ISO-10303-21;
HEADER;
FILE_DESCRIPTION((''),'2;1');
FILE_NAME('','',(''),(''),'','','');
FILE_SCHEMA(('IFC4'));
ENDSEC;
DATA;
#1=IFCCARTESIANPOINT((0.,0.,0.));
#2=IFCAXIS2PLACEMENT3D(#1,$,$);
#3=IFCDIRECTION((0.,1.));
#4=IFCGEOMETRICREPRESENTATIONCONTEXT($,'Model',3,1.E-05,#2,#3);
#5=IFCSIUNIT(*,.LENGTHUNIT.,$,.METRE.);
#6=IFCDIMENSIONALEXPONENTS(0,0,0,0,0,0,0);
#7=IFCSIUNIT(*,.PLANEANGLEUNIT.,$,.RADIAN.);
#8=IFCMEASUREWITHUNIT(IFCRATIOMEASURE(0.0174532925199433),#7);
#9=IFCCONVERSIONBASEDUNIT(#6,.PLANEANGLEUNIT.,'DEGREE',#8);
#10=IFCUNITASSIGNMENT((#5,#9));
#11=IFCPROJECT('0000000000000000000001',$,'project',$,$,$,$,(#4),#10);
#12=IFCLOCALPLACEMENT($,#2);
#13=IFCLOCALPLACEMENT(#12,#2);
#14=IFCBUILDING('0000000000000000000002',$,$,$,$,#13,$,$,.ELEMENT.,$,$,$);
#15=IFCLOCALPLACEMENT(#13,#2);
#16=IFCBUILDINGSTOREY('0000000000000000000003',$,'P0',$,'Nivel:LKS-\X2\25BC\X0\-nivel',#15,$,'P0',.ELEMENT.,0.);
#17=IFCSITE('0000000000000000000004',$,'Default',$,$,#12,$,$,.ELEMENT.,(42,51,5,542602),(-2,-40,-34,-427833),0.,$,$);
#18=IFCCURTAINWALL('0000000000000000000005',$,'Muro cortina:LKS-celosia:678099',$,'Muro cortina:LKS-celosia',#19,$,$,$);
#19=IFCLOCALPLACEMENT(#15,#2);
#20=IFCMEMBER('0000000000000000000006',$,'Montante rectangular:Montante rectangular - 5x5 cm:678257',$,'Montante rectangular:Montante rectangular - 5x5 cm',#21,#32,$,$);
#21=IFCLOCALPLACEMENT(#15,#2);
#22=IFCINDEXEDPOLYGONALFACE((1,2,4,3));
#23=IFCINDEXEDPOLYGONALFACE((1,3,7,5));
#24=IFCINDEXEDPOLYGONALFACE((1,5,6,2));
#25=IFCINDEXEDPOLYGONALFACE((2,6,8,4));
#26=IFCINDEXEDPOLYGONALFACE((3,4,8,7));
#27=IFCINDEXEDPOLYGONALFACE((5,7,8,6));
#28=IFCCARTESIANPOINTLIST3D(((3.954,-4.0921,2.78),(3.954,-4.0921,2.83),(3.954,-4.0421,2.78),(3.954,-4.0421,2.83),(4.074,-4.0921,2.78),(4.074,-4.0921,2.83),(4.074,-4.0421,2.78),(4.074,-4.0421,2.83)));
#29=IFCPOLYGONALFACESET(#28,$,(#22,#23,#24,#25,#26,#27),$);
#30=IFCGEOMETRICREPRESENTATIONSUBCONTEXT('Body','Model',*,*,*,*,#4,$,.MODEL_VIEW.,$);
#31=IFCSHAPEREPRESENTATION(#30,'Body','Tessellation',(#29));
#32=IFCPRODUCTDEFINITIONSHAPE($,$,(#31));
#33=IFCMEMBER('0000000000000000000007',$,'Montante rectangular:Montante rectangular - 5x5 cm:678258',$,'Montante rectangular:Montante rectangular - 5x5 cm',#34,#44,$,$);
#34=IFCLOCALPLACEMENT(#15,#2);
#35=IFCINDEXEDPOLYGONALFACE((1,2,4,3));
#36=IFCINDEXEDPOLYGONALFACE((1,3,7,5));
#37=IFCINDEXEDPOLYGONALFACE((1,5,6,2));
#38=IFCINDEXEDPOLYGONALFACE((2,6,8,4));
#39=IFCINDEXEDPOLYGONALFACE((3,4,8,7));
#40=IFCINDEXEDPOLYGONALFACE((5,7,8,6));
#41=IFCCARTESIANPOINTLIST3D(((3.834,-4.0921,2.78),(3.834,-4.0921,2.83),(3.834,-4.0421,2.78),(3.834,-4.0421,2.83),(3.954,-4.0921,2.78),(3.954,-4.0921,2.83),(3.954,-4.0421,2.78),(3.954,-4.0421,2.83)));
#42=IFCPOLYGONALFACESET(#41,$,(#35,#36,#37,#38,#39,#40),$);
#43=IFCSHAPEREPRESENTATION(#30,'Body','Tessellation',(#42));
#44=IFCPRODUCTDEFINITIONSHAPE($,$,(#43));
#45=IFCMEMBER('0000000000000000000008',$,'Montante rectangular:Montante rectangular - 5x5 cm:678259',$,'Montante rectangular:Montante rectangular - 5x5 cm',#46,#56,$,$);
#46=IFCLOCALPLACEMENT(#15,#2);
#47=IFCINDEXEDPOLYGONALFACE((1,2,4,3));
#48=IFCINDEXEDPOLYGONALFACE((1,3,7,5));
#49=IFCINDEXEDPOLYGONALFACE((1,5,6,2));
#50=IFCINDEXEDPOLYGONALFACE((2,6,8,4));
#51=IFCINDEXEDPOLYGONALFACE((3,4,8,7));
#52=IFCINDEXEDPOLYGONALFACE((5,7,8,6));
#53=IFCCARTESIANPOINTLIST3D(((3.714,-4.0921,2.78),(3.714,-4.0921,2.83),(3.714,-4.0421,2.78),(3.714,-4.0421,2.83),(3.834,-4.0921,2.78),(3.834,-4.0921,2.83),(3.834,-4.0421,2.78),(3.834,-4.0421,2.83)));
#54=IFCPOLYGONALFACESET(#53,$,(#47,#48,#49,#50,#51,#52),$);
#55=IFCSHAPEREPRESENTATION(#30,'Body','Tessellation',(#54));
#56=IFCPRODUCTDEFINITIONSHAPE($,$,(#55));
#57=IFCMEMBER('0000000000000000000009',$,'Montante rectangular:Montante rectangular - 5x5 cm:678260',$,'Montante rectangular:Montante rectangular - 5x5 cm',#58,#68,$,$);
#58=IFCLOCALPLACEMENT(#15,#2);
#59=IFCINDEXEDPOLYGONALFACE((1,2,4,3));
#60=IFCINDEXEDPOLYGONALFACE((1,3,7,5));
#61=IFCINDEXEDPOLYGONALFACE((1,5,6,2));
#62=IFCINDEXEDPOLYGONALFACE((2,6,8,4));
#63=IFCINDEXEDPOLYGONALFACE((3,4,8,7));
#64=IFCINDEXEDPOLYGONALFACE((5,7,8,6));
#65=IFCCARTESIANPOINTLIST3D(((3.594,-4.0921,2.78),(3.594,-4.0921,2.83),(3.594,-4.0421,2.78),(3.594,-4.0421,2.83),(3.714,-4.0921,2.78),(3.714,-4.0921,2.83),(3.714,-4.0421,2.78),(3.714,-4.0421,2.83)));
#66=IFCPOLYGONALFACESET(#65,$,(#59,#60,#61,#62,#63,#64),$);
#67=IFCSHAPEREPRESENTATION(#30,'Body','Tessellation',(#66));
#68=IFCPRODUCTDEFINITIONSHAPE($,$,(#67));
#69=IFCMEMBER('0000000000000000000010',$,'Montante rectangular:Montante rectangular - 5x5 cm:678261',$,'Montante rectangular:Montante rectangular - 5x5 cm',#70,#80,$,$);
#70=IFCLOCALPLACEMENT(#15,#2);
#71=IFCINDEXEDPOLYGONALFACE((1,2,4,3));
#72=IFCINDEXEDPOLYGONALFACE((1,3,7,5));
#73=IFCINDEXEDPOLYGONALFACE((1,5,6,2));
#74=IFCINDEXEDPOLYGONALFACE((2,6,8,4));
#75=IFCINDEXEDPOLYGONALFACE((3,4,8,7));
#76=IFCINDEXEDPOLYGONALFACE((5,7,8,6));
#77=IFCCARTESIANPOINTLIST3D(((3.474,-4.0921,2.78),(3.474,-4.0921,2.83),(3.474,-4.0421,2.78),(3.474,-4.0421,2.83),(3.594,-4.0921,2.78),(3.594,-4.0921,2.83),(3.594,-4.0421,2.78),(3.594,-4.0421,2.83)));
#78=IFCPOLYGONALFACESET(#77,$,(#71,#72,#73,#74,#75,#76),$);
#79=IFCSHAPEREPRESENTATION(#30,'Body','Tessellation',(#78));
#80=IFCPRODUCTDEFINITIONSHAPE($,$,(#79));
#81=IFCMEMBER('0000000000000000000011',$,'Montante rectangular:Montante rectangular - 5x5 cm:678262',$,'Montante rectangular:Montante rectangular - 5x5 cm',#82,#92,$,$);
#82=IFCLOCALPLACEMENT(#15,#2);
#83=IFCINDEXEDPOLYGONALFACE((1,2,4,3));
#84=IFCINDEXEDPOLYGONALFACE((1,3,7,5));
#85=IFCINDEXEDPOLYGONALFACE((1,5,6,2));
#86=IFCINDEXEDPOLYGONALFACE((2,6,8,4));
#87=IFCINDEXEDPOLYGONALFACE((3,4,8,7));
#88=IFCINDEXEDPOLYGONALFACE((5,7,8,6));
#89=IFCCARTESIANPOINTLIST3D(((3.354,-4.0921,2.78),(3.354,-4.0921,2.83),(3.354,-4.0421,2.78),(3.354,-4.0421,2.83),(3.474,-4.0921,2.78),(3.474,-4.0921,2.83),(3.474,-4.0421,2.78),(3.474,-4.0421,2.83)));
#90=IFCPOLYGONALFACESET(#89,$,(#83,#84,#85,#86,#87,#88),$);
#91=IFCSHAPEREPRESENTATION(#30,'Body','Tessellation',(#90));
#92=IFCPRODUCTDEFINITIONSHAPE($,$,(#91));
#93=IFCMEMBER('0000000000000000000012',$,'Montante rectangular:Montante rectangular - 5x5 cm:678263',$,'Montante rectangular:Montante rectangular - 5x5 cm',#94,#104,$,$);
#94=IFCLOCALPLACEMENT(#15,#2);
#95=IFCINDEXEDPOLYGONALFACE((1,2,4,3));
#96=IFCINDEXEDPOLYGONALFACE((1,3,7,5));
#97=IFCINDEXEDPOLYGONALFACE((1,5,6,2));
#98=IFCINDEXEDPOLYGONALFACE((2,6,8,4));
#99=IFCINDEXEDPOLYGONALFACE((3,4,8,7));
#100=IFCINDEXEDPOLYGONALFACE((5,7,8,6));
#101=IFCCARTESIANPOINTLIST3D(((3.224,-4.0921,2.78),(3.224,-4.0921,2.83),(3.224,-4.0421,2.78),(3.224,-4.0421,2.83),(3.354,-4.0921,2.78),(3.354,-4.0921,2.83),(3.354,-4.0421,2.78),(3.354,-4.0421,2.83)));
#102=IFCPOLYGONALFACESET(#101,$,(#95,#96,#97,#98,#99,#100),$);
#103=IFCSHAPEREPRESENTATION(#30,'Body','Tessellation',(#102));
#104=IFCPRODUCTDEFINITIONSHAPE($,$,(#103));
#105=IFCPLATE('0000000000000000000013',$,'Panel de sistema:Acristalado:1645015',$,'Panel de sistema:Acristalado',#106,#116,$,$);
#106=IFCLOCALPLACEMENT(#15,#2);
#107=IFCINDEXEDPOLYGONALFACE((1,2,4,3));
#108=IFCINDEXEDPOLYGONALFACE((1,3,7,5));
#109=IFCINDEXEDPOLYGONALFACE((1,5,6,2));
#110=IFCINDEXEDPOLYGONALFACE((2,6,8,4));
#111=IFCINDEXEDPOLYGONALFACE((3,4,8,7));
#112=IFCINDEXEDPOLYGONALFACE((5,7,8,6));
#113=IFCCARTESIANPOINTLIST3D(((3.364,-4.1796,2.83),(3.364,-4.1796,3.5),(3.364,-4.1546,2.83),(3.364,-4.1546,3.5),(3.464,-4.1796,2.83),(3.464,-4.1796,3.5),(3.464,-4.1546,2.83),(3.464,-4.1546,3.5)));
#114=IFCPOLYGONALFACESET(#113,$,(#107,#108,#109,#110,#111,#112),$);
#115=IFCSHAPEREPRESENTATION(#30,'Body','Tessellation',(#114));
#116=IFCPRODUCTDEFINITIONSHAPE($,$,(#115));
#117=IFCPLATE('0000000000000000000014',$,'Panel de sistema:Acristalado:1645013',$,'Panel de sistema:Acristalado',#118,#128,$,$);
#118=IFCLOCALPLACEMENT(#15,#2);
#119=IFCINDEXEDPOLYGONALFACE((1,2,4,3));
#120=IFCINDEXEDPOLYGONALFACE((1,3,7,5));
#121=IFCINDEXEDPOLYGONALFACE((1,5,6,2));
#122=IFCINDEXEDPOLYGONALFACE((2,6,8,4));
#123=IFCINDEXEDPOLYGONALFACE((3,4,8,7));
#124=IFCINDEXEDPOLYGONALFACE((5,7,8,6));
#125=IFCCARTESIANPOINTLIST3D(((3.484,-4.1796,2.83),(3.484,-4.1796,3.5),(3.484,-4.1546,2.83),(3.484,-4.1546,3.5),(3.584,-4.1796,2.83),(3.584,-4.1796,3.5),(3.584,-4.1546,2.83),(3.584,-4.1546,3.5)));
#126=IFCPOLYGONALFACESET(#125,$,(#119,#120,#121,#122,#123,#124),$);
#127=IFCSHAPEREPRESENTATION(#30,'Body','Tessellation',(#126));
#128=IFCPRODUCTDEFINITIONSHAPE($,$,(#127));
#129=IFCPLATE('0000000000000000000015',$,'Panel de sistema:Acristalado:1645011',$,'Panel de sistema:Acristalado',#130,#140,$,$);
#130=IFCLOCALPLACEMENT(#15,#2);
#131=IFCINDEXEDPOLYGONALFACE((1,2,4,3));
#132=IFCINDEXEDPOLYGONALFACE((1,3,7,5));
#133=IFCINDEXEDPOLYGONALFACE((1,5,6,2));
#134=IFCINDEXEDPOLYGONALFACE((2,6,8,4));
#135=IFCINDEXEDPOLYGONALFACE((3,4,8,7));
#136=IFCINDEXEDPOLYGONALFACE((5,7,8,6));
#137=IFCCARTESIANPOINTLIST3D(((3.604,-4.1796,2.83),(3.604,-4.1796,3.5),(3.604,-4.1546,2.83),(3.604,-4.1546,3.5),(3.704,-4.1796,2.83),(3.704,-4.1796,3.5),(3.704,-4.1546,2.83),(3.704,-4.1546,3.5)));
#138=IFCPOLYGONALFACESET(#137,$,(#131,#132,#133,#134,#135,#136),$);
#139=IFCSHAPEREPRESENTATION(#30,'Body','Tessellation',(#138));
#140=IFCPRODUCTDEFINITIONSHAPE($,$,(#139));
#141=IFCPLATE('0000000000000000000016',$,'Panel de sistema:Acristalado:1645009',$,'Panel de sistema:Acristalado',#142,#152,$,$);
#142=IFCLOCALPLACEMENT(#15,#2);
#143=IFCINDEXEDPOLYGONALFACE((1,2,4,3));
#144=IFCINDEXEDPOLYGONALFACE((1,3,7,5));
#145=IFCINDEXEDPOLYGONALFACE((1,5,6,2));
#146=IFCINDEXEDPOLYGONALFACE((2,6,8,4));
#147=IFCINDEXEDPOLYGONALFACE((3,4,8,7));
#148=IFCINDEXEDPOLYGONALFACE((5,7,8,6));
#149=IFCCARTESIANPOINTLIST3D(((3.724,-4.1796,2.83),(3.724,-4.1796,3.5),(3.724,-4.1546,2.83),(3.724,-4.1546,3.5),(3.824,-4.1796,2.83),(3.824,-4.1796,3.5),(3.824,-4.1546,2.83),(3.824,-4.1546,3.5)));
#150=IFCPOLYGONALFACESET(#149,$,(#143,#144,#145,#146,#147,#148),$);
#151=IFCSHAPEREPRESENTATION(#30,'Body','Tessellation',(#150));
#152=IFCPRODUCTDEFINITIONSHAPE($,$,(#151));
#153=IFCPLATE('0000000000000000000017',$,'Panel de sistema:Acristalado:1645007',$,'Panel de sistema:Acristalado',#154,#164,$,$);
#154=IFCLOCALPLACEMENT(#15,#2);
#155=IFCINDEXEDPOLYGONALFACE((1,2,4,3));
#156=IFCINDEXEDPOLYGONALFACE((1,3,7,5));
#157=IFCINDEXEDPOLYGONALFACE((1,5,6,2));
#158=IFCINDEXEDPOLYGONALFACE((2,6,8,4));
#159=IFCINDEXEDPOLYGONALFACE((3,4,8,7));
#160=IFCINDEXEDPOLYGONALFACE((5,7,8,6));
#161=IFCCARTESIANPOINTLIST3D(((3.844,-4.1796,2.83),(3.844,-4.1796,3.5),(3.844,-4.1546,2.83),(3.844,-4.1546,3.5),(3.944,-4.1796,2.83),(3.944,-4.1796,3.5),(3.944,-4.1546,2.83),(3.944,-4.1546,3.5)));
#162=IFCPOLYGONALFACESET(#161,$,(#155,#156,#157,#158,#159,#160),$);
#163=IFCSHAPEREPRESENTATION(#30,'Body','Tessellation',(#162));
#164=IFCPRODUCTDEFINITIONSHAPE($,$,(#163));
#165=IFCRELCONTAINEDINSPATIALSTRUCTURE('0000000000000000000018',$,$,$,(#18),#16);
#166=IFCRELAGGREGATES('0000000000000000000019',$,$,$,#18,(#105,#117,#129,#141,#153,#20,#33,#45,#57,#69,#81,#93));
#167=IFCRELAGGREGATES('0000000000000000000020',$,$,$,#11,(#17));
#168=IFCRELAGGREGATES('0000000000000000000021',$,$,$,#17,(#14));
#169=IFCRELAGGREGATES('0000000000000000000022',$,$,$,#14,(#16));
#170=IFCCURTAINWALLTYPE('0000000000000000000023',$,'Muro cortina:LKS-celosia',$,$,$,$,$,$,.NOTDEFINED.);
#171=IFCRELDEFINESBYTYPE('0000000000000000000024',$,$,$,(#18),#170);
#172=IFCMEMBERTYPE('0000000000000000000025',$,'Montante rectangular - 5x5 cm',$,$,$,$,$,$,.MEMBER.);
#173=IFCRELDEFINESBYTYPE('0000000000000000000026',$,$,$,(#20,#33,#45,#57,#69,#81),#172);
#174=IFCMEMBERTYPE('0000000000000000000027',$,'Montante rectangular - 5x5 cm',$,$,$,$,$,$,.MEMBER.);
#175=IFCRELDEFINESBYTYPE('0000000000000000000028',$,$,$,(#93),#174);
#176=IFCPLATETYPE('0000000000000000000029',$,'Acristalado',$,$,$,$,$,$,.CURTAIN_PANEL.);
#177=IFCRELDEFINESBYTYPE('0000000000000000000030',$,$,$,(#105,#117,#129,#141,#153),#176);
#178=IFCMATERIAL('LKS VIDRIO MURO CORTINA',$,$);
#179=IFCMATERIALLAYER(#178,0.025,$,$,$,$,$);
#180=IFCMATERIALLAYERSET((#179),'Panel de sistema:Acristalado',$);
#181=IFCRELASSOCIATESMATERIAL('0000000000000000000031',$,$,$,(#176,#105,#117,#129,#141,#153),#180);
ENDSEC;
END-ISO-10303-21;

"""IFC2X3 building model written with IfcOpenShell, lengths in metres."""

from ifc_helpers import new_model, entity, si_unit, converted_unit, direction, frame, origin, origin_2d_with_axis, place, context, subcontext, project, spatial, rectangle, extrude, source, transform, mapped, material, layer, layer_set, layer_usage, type_object, type_shapes, element, aggregate, save


model = new_model("IFC2X3")

# Units and contexts
model_context = context("Model", 3, precision=1e-05, world=origin(), true_north=direction((0.0, 1.0)))
body_context = subcontext(model_context, "Body", "Model", "MODEL_VIEW")
ifc_project = project(units=[si_unit("LENGTHUNIT", "METRE"), converted_unit("PLANEANGLEUNIT", "DEGREE", entity("IfcRatioMeasure", 0.0174532925199433), si_unit("PLANEANGLEUNIT", "RADIAN"), dimensions=[0, 0, 0, 0, 0, 0, 0])], contexts=[model_context])

# Site, building, storey
site_placement = place(None, origin())
site = spatial("IfcSite", under=ifc_project, at=site_placement, Name="Default", CompositionType="ELEMENT", RefLatitude=(42, 51, 5, 542602), RefLongitude=(-2, -40, -34, -427833), RefElevation=0.0)
building_placement = place(site_placement, origin())
building = spatial("IfcBuilding", under=site, at=building_placement, CompositionType="ELEMENT")
storey_placement = place(building_placement, origin())
storey = spatial("IfcBuildingStorey", under=building, at=storey_placement, Name="P0", ObjectType="Nivel:LKS-▼-nivel", LongName="P0", CompositionType="ELEMENT", Elevation=0.0)

# Curtain wall, members, plates
curtain_wall_type = type_object("IfcCurtainWallType", Name="Muro cortina:LKS-celosia", PredefinedType="NOTDEFINED")
curtain_wall_placement = place(storey_placement, origin())
curtain_wall = element("IfcCurtainWall", 1, at=curtain_wall_placement, inside=storey, type_object=curtain_wall_type, Name="Muro cortina:LKS-celosia:678099", ObjectType="Muro cortina:LKS-celosia")
member_type_1 = type_object("IfcMemberType", Name="Montante rectangular - 5x5 cm", PredefinedType="MEMBER")
shared_shape_1 = source(origin(), body_context, "Body", "SweptSolid", [
    extrude(rectangle(XDim=0.05, YDim=0.05, at=origin_2d_with_axis()), frame((-0.025, -0.1, -0.12), z_axis=(0.0, 0.0, 1.0), x_axis=(0.0, -1.0, 0.0)), (0.0, 0.0, 1.0), 0.12),
])
type_shapes(member_type_1, [shared_shape_1])
member_1_placement = place(storey_placement, frame((3.954, -4.1671, 2.78), z_axis=(-1.0, 0.0, 0.0), x_axis=(0.0, 0.0, -1.0)))
member_1 = element("IfcMember", 2, at=member_1_placement, type_object=member_type_1, Name="Montante rectangular:Montante rectangular - 5x5 cm:678257", ObjectType="Montante rectangular:Montante rectangular - 5x5 cm", context=body_context, shape_type="MappedRepresentation", body=[
    mapped(shared_shape_1, transform((0.0, 0.0, 0.0), scale=1.0)),
])
member_2_placement = place(storey_placement, frame((3.834, -4.1671, 2.78), z_axis=(-1.0, 0.0, 0.0), x_axis=(0.0, 0.0, -1.0)))
member_2 = element("IfcMember", 3, at=member_2_placement, type_object=member_type_1, Name="Montante rectangular:Montante rectangular - 5x5 cm:678258", ObjectType="Montante rectangular:Montante rectangular - 5x5 cm", context=body_context, shape_type="MappedRepresentation", body=[
    mapped(shared_shape_1, transform((0.0, 0.0, 0.0), scale=1.0)),
])
member_3_placement = place(storey_placement, frame((3.714, -4.1671, 2.78), z_axis=(-1.0, 0.0, 0.0), x_axis=(0.0, 0.0, -1.0)))
member_3 = element("IfcMember", 4, at=member_3_placement, type_object=member_type_1, Name="Montante rectangular:Montante rectangular - 5x5 cm:678259", ObjectType="Montante rectangular:Montante rectangular - 5x5 cm", context=body_context, shape_type="MappedRepresentation", body=[
    mapped(shared_shape_1, transform((0.0, 0.0, 0.0), scale=1.0)),
])
member_4_placement = place(storey_placement, frame((3.594, -4.1671, 2.78), z_axis=(-1.0, 0.0, 0.0), x_axis=(0.0, 0.0, -1.0)))
member_4 = element("IfcMember", 5, at=member_4_placement, type_object=member_type_1, Name="Montante rectangular:Montante rectangular - 5x5 cm:678260", ObjectType="Montante rectangular:Montante rectangular - 5x5 cm", context=body_context, shape_type="MappedRepresentation", body=[
    mapped(shared_shape_1, transform((0.0, 0.0, 0.0), scale=1.0)),
])
member_5_placement = place(storey_placement, frame((3.474, -4.1671, 2.78), z_axis=(-1.0, 0.0, 0.0), x_axis=(0.0, 0.0, -1.0)))
member_5 = element("IfcMember", 6, at=member_5_placement, type_object=member_type_1, Name="Montante rectangular:Montante rectangular - 5x5 cm:678261", ObjectType="Montante rectangular:Montante rectangular - 5x5 cm", context=body_context, shape_type="MappedRepresentation", body=[
    mapped(shared_shape_1, transform((0.0, 0.0, 0.0), scale=1.0)),
])
member_6_placement = place(storey_placement, frame((3.354, -4.1671, 2.78), z_axis=(-1.0, 0.0, 0.0), x_axis=(0.0, 0.0, -1.0)))
member_6 = element("IfcMember", 7, at=member_6_placement, type_object=member_type_1, Name="Montante rectangular:Montante rectangular - 5x5 cm:678262", ObjectType="Montante rectangular:Montante rectangular - 5x5 cm", context=body_context, shape_type="MappedRepresentation", body=[
    mapped(shared_shape_1, transform((0.0, 0.0, 0.0), scale=1.0)),
])
member_type_2 = type_object("IfcMemberType", Name="Montante rectangular - 5x5 cm", PredefinedType="MEMBER")
shared_shape_2 = source(origin(), body_context, "Body", "SweptSolid", [
    extrude(rectangle(XDim=0.05, YDim=0.05, at=origin_2d_with_axis()), frame((-0.025, -0.1, -0.13), z_axis=(0.0, 0.0, 1.0), x_axis=(0.0, -1.0, 0.0)), (0.0, 0.0, 1.0), 0.13),
])
type_shapes(member_type_2, [shared_shape_2])
member_7_placement = place(storey_placement, frame((3.224, -4.1671, 2.78), z_axis=(-1.0, 0.0, 0.0), x_axis=(0.0, 0.0, -1.0)))
member_7 = element("IfcMember", 8, at=member_7_placement, type_object=member_type_2, Name="Montante rectangular:Montante rectangular - 5x5 cm:678263", ObjectType="Montante rectangular:Montante rectangular - 5x5 cm", context=body_context, shape_type="MappedRepresentation", body=[
    mapped(shared_shape_2, transform((0.0, 0.0, 0.0), scale=1.0)),
])
ifc_material_1 = material(Name="LKS VIDRIO MURO CORTINA")
ifc_layer_1 = layer(ifc_material_1, 0.025)
ifc_layer_set_1 = layer_set([ifc_layer_1], Name="Panel de sistema:Acristalado")
ifc_layer_usage_1 = layer_usage(ifc_layer_set_1, "AXIS3", "POSITIVE", 0.0)
plate_type = type_object("IfcPlateType", Name="Acristalado", PredefinedType="CURTAIN_PANEL", material=ifc_layer_set_1)
shared_shape_3 = source(origin(), body_context, "Body", "SweptSolid", [
    extrude(rectangle(XDim=0.025, YDim=0.1, at=origin_2d_with_axis()), frame((0.0, 0.0, 0.0), z_axis=(0.0, 0.0, 1.0), x_axis=(0.0, 1.0, 0.0)), (0.0, 0.0, 1.0), 0.67),
])
type_shapes(plate_type, [shared_shape_3])
plate_1_placement = place(curtain_wall_placement, frame((3.414, -4.1671, 2.83)))
plate_1 = element("IfcPlate", 9, at=plate_1_placement, type_object=plate_type, material=ifc_layer_usage_1, Name="Panel de sistema:Acristalado:1645015", ObjectType="Panel de sistema:Acristalado", context=body_context, shape_type="MappedRepresentation", body=[
    mapped(shared_shape_3, transform((0.0, 0.0, 0.0), scale=1.0)),
])
ifc_layer_usage_2 = layer_usage(ifc_layer_set_1, "AXIS3", "POSITIVE", 0.0)
plate_2_placement = place(curtain_wall_placement, frame((3.534, -4.1671, 2.83)))
plate_2 = element("IfcPlate", 10, at=plate_2_placement, type_object=plate_type, material=ifc_layer_usage_2, Name="Panel de sistema:Acristalado:1645013", ObjectType="Panel de sistema:Acristalado", context=body_context, shape_type="MappedRepresentation", body=[
    mapped(shared_shape_3, transform((0.0, 0.0, 0.0), scale=1.0)),
])
ifc_layer_usage_3 = layer_usage(ifc_layer_set_1, "AXIS3", "POSITIVE", 0.0)
plate_3_placement = place(curtain_wall_placement, frame((3.654, -4.1671, 2.83)))
plate_3 = element("IfcPlate", 11, at=plate_3_placement, type_object=plate_type, material=ifc_layer_usage_3, Name="Panel de sistema:Acristalado:1645011", ObjectType="Panel de sistema:Acristalado", context=body_context, shape_type="MappedRepresentation", body=[
    mapped(shared_shape_3, transform((0.0, 0.0, 0.0), scale=1.0)),
])
ifc_layer_usage_4 = layer_usage(ifc_layer_set_1, "AXIS3", "POSITIVE", 0.0)
plate_4_placement = place(curtain_wall_placement, frame((3.774, -4.1671, 2.83)))
plate_4 = element("IfcPlate", 12, at=plate_4_placement, type_object=plate_type, material=ifc_layer_usage_4, Name="Panel de sistema:Acristalado:1645009", ObjectType="Panel de sistema:Acristalado", context=body_context, shape_type="MappedRepresentation", body=[
    mapped(shared_shape_3, transform((0.0, 0.0, 0.0), scale=1.0)),
])
ifc_layer_usage_5 = layer_usage(ifc_layer_set_1, "AXIS3", "POSITIVE", 0.0)
plate_5_placement = place(curtain_wall_placement, frame((3.894, -4.1671, 2.83)))
plate_5 = element("IfcPlate", 13, at=plate_5_placement, type_object=plate_type, material=ifc_layer_usage_5, Name="Panel de sistema:Acristalado:1645007", ObjectType="Panel de sistema:Acristalado", context=body_context, shape_type="MappedRepresentation", body=[
    mapped(shared_shape_3, transform((0.0, 0.0, 0.0), scale=1.0)),
])
aggregate(curtain_wall, [plate_1, plate_2, plate_3, plate_4, plate_5, member_1, member_2, member_3, member_4, member_5, member_6, member_7])

save(model, "model.ifc")
